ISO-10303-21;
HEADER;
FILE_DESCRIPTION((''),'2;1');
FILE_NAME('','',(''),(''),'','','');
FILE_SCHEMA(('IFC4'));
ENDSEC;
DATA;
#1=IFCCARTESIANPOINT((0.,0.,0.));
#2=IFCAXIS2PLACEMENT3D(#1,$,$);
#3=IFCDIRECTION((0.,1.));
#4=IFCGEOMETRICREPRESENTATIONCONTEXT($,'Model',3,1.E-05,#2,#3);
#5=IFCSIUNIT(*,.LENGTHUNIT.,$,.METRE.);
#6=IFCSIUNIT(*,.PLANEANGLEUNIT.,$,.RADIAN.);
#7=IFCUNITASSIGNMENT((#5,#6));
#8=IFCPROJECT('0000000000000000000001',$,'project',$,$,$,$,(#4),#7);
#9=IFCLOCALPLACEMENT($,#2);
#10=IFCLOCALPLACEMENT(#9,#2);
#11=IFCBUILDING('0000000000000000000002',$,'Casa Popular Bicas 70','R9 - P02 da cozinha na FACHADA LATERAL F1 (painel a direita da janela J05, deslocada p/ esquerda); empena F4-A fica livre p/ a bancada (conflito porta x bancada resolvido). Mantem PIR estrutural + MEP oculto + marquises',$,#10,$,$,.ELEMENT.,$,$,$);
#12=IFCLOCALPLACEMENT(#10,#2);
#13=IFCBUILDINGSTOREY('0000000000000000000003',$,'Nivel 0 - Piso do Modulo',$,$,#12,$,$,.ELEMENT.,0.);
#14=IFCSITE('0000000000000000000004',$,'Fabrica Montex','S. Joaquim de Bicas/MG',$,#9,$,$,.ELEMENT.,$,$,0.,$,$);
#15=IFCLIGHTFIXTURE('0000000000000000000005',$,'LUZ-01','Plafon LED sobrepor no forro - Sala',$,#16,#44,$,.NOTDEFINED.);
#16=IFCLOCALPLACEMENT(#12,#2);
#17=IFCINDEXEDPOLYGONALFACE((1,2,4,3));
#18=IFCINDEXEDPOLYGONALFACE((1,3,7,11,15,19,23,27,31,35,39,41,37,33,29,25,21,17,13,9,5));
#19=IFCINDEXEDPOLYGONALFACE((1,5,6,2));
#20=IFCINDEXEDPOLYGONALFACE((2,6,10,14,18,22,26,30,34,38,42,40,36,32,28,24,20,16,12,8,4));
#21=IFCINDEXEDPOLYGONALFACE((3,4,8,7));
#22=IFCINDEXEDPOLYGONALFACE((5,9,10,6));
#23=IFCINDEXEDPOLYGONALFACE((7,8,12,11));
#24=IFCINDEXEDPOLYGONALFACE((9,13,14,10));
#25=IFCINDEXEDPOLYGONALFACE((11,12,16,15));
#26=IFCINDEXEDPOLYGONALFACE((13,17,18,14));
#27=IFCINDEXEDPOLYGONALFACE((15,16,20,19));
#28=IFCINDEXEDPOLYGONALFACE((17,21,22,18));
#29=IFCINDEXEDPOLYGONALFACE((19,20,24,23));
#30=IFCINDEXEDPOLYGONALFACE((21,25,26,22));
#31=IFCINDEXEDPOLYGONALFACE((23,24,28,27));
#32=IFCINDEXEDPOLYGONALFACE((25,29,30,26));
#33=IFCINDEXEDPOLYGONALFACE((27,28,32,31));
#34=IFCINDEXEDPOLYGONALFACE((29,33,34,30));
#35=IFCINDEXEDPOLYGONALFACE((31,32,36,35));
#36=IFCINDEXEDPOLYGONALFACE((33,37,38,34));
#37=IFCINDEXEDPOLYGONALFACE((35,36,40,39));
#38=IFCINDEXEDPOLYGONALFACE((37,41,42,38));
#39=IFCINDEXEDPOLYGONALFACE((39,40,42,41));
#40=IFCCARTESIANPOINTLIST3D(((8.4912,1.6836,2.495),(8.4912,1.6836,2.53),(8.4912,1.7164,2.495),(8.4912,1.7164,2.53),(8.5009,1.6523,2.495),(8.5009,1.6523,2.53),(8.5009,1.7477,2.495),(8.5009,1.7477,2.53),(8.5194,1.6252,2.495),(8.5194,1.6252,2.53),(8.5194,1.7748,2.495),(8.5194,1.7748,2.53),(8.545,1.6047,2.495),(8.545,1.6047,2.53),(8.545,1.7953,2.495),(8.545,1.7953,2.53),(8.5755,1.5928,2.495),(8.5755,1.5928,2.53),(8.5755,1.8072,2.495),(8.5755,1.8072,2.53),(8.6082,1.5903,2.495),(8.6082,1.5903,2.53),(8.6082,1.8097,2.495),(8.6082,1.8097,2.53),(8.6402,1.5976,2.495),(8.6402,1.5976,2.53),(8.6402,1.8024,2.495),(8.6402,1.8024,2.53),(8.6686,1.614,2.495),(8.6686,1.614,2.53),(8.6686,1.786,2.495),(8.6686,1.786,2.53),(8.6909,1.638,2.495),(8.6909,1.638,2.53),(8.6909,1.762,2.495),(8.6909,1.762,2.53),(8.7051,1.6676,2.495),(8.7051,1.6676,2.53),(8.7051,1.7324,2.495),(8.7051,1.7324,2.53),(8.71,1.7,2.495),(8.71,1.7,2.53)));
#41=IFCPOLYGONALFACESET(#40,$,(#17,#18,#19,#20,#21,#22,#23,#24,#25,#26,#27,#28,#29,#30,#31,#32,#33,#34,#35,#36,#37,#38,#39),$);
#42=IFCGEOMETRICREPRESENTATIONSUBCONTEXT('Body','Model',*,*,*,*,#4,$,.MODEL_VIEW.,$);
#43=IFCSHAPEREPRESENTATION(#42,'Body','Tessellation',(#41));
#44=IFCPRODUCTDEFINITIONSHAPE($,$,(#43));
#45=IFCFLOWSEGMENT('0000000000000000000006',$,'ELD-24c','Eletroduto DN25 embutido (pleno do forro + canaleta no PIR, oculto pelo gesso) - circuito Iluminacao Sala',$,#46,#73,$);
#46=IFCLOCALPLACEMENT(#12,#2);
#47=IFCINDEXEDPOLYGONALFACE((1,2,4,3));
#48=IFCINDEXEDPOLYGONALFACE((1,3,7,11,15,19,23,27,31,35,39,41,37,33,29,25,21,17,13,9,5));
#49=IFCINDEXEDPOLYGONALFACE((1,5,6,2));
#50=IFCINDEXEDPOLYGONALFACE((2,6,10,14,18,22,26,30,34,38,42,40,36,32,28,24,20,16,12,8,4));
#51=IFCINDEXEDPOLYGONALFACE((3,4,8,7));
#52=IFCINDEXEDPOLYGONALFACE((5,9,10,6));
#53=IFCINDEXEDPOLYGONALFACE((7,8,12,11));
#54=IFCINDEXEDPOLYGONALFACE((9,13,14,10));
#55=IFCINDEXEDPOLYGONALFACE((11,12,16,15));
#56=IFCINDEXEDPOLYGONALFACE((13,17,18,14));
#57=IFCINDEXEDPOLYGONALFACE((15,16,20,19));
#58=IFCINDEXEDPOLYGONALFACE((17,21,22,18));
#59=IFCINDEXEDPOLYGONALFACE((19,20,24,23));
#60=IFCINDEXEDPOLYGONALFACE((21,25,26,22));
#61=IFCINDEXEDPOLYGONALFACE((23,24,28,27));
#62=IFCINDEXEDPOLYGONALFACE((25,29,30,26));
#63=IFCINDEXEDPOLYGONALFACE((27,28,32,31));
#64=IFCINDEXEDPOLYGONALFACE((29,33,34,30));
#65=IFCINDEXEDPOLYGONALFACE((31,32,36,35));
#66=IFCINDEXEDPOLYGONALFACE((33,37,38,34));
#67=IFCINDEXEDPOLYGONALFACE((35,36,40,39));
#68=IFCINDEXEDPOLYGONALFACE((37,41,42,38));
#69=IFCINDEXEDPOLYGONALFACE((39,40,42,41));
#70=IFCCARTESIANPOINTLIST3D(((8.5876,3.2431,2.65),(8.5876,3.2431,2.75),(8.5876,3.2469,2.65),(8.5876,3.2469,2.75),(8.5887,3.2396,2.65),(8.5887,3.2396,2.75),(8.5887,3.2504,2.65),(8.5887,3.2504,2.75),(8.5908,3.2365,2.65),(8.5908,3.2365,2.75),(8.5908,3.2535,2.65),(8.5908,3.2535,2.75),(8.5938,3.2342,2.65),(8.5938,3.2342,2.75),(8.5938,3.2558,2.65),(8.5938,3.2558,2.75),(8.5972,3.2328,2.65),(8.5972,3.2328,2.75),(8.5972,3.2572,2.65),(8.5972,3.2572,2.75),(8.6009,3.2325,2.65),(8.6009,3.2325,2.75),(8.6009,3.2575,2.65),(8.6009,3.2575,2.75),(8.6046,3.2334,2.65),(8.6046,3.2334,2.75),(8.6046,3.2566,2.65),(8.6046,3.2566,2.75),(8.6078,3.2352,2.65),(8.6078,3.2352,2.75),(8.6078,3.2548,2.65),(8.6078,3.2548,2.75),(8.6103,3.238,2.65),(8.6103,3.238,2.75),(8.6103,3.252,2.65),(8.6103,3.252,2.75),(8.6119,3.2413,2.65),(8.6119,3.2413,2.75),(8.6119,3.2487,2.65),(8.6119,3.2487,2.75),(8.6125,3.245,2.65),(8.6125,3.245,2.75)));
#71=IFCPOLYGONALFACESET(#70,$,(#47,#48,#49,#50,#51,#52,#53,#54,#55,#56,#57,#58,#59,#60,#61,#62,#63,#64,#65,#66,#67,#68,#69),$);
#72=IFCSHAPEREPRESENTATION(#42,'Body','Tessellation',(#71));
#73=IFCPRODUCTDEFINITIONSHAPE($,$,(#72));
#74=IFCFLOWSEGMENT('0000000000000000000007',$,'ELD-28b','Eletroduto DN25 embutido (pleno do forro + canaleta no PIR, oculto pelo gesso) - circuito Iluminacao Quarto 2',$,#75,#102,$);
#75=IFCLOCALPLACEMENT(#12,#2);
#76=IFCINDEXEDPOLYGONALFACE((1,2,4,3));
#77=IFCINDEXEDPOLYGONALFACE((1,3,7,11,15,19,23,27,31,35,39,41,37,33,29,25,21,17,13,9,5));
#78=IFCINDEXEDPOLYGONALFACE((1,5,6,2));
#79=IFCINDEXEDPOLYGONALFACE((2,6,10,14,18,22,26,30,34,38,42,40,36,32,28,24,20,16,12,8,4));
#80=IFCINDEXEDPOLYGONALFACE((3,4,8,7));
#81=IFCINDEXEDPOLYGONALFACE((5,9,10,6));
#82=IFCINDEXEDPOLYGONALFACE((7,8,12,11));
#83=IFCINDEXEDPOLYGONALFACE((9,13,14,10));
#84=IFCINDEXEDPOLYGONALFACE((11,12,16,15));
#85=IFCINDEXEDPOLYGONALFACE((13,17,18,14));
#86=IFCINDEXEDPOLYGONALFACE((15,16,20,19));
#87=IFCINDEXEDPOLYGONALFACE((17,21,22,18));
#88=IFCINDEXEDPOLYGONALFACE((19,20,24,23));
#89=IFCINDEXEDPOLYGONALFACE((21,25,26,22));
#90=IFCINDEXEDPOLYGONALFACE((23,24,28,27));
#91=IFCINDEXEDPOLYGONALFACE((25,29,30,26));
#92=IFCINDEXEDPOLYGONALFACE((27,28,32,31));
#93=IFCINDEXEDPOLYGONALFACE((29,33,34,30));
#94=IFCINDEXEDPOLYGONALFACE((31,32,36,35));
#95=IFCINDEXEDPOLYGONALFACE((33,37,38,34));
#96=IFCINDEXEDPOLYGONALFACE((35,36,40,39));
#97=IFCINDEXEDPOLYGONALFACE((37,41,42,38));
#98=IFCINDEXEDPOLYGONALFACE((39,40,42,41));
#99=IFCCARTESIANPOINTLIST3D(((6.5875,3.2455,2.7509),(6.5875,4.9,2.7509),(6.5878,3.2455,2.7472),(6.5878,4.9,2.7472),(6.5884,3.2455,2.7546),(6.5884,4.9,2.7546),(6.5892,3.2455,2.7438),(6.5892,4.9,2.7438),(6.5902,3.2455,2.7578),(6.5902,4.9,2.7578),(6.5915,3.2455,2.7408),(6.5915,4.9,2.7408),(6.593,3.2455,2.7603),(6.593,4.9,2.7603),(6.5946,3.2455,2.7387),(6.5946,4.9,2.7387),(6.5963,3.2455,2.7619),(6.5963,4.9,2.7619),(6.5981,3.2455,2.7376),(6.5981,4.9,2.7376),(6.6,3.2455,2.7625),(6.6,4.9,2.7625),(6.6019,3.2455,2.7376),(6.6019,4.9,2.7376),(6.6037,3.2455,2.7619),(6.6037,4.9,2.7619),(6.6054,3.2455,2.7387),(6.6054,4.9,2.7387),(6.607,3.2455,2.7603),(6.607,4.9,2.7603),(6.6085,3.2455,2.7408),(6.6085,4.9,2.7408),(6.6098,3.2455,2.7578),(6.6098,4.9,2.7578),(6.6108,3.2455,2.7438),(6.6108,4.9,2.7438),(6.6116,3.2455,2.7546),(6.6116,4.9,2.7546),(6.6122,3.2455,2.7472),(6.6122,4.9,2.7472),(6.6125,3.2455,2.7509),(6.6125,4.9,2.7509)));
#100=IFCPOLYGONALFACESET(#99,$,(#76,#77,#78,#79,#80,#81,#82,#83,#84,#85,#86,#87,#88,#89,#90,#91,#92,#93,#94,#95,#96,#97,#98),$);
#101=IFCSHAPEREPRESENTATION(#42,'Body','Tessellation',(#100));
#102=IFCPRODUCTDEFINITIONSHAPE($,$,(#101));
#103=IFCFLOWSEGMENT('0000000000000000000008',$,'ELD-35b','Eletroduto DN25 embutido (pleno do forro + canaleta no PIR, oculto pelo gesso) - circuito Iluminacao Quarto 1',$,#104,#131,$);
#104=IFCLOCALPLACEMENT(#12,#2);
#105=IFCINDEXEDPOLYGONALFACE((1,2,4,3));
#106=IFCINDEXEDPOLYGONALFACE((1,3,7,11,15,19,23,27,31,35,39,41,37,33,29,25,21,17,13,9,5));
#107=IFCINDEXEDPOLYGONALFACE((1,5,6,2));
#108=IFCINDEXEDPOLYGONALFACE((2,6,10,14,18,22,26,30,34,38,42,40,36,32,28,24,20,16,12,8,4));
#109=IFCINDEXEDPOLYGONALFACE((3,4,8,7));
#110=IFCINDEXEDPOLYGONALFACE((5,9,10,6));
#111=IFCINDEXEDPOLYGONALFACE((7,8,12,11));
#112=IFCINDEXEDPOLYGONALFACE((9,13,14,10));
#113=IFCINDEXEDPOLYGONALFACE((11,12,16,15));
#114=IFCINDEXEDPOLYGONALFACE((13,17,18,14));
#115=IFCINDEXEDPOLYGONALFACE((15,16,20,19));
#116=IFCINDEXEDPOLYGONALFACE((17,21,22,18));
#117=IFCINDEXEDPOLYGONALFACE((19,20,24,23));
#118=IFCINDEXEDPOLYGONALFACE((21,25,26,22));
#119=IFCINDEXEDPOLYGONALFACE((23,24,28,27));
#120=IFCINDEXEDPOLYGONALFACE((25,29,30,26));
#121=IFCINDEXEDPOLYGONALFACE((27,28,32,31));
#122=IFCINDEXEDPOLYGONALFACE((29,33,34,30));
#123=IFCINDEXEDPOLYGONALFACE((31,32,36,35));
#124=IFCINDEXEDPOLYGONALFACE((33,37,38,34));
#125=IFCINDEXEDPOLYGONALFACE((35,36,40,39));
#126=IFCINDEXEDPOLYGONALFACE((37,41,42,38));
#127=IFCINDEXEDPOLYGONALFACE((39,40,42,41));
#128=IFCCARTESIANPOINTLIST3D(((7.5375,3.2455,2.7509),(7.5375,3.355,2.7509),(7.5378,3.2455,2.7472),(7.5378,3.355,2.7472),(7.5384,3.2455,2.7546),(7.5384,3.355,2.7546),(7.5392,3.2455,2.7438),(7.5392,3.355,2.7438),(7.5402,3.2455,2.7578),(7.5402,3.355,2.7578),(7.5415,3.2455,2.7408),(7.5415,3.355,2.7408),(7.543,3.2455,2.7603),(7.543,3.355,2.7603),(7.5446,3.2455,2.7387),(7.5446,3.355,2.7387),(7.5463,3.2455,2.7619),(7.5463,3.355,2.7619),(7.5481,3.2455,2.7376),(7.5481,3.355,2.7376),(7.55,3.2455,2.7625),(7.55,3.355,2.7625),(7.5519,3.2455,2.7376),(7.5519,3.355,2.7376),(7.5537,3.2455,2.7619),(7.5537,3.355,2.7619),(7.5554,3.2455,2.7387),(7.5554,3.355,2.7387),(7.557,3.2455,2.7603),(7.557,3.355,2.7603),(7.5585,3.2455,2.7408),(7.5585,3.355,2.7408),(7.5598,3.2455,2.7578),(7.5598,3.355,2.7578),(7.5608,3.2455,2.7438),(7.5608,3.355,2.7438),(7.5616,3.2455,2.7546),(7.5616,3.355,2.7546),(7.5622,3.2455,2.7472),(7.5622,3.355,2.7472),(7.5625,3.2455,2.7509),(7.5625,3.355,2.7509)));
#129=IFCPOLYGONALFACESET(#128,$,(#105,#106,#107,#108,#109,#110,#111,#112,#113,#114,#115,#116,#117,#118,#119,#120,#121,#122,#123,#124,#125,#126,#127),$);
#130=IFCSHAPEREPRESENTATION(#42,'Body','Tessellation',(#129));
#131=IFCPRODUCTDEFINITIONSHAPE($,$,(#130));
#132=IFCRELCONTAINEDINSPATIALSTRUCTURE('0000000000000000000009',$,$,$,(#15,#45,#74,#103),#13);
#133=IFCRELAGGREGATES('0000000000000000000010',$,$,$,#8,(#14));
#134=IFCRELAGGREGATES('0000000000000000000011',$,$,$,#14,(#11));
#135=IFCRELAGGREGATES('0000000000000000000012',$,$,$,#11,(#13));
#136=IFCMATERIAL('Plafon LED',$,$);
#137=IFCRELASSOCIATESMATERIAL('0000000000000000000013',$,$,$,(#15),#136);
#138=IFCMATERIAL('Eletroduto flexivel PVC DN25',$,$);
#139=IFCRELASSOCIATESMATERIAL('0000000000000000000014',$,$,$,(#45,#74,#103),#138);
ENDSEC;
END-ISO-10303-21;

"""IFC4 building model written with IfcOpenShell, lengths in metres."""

from ifc_helpers import new_model, si_unit, direction, frame, origin, origin_2d, place, context, subcontext, project, spatial, circle, extrude, material, element, save


model = new_model("IFC4")

# Units and contexts
model_context = context("Model", 3, precision=1e-05, world=origin(), true_north=direction((0.0, 1.0)))
body_context = subcontext(model_context, "Body", "Model", "MODEL_VIEW")
ifc_project = project(units=[si_unit("LENGTHUNIT", "METRE"), si_unit("PLANEANGLEUNIT", "RADIAN")], contexts=[model_context])

# Site, building, storey
site_placement = place(None, origin())
site = spatial("IfcSite", under=ifc_project, at=site_placement, Name="Fabrica Montex", Description="S. Joaquim de Bicas/MG", CompositionType="ELEMENT", RefElevation=0.0)
building_placement = place(site_placement, origin())
building = spatial("IfcBuilding", under=site, at=building_placement, Name="Casa Popular Bicas 70", Description="R9 - P02 da cozinha na FACHADA LATERAL F1 (painel a direita da janela J05, deslocada p/ esquerda); empena F4-A fica livre p/ a bancada (conflito porta x bancada resolvido). Mantem PIR estrutural + MEP oculto + marquises", CompositionType="ELEMENT")
storey_placement = place(building_placement, origin())
storey = spatial("IfcBuildingStorey", under=building, at=storey_placement, Name="Nivel 0 - Piso do Modulo", CompositionType="ELEMENT", Elevation=0.0)

# Shared definitions
ifc_material_1 = material(Name="Eletroduto flexivel PVC DN25")

# Light fixture
ifc_material_2 = material(Name="Plafon LED")
light_fixture_placement = place(storey_placement, frame((8.6, 1.7, 2.495)))
element("IfcLightFixture", 1, at=light_fixture_placement, inside=storey, material=ifc_material_2, Name="LUZ-01", Description="Plafon LED sobrepor no forro - Sala", PredefinedType="NOTDEFINED", context=body_context, shape_type="SweptSolid", body=[
    extrude(circle(Radius=0.11, at=origin_2d()), origin(), (0.0, 0.0, 1.0), 0.035),
])

# Flow segments
flow_segment_1_placement = place(storey_placement, frame((8.6, 3.245, 2.75), z_axis=(0.0, 0.0, -1.0), x_axis=(1.0, 0.0, 0.0)))
element("IfcFlowSegment", 2, at=flow_segment_1_placement, inside=storey, material=ifc_material_1, Name="ELD-24c", Description="Eletroduto DN25 embutido (pleno do forro + canaleta no PIR, oculto pelo gesso) - circuito Iluminacao Sala", context=body_context, shape_type="SweptSolid", body=[
    extrude(circle(Radius=0.0125, at=origin_2d()), origin(), (0.0, 0.0, 1.0), 0.1),
])
flow_segment_2_placement = place(storey_placement, frame((6.6, 3.2455, 2.75), z_axis=(0.0, 1.0, 0.0), x_axis=(0.0, 0.0, 1.0)))
element("IfcFlowSegment", 3, at=flow_segment_2_placement, inside=storey, material=ifc_material_1, Name="ELD-28b", Description="Eletroduto DN25 embutido (pleno do forro + canaleta no PIR, oculto pelo gesso) - circuito Iluminacao Quarto 2", context=body_context, shape_type="SweptSolid", body=[
    extrude(circle(Radius=0.0125, at=origin_2d()), origin(), (0.0, 0.0, 1.0), 1.6545),
])
flow_segment_3_placement = place(storey_placement, frame((7.55, 3.2455, 2.75), z_axis=(0.0, 1.0, 0.0), x_axis=(0.0, 0.0, 1.0)))
element("IfcFlowSegment", 4, at=flow_segment_3_placement, inside=storey, material=ifc_material_1, Name="ELD-35b", Description="Eletroduto DN25 embutido (pleno do forro + canaleta no PIR, oculto pelo gesso) - circuito Iluminacao Quarto 1", context=body_context, shape_type="SweptSolid", body=[
    extrude(circle(Radius=0.0125, at=origin_2d()), origin(), (0.0, 0.0, 1.0), 0.1095),
])

save(model, "model.ifc")
